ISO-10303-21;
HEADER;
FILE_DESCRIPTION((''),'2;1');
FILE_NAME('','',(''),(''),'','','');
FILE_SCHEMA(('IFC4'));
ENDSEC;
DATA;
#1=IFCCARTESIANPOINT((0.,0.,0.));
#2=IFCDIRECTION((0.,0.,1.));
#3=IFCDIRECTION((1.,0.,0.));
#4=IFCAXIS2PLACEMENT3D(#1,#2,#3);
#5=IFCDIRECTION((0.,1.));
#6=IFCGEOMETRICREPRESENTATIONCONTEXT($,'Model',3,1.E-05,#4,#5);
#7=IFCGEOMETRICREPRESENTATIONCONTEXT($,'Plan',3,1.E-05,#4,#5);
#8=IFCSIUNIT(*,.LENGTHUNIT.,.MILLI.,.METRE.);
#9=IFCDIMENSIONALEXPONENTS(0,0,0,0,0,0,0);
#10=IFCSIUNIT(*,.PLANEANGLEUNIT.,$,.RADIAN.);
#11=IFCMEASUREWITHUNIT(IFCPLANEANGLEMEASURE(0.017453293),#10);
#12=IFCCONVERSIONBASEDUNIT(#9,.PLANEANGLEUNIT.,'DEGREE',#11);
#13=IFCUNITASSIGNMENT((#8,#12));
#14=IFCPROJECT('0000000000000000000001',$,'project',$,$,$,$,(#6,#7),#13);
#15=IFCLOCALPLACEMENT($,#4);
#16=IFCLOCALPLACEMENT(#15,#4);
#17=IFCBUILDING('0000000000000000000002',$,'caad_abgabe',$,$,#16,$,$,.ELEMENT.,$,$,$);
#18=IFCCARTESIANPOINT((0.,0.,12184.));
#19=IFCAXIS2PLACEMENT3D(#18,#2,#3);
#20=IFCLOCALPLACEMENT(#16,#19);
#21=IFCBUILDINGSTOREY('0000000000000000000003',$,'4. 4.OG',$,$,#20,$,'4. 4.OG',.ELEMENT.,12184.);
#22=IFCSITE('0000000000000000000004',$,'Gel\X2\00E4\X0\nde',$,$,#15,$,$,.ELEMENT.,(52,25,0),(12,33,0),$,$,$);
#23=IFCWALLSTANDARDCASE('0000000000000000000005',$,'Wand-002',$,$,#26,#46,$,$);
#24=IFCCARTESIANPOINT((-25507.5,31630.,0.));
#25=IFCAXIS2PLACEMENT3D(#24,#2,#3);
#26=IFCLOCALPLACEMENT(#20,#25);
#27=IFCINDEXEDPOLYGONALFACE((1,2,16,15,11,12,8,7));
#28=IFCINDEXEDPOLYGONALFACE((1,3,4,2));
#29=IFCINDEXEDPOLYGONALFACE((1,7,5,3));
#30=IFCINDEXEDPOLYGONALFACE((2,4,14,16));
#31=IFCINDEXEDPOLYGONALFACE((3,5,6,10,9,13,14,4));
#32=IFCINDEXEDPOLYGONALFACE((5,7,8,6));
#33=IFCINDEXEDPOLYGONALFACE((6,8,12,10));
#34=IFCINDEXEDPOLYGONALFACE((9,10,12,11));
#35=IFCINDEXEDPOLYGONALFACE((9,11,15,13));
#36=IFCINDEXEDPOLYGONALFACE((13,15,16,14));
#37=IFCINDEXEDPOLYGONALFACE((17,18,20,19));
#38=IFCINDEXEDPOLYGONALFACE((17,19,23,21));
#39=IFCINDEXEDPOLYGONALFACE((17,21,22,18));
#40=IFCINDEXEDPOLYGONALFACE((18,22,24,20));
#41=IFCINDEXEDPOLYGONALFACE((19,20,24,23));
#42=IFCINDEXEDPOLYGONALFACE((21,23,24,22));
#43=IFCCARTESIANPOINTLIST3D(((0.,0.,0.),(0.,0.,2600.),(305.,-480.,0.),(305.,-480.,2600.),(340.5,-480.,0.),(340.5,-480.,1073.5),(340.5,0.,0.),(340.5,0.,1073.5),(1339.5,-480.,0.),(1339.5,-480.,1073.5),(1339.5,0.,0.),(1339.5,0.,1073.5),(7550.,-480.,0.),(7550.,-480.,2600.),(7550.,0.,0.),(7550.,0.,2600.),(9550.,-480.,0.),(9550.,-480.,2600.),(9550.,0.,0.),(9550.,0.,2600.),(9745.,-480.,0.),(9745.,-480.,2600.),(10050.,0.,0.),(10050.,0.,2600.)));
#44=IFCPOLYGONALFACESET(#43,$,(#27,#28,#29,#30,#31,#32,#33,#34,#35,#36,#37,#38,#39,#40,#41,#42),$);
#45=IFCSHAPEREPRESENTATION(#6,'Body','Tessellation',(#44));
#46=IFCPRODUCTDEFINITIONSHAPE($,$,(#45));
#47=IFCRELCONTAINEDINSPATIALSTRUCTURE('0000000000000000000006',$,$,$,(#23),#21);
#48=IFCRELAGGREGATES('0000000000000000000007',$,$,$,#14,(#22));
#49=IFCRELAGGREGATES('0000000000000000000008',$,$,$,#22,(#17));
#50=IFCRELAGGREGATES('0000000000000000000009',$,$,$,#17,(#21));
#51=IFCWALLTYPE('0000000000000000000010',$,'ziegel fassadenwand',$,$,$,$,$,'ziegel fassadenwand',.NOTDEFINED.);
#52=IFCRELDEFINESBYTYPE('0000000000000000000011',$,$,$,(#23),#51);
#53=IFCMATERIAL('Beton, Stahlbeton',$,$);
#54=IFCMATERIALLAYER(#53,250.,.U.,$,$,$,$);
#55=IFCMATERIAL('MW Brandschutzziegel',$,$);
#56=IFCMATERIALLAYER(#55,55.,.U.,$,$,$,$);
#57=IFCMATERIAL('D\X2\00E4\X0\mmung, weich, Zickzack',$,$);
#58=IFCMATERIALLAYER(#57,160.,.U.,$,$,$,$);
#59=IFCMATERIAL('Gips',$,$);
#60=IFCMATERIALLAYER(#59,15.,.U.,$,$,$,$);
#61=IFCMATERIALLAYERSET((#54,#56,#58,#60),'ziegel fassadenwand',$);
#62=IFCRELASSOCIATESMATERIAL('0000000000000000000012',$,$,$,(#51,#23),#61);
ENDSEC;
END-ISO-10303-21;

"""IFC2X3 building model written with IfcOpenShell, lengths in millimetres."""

from ifc_helpers import new_model, entity, si_unit, converted_unit, direction, frame, frame_2d, origin_with_axes, place, context, project, spatial, polyline, rectangle, outline, extrude, material, layer, layer_set, layer_usage, type_object, element, save


model = new_model("IFC2X3")

# Units and contexts
model_context = context("Model", 3, precision=1e-05, world=origin_with_axes(), true_north=direction((0.0, 1.0)))
plan_context = context("Plan", 3, precision=1e-05, world=origin_with_axes(), true_north=direction((0.0, 1.0)))
ifc_project = project(units=[si_unit("LENGTHUNIT", "METRE", prefix="MILLI"), converted_unit("PLANEANGLEUNIT", "DEGREE", entity("IfcPlaneAngleMeasure", 0.017453293), si_unit("PLANEANGLEUNIT", "RADIAN"), dimensions=[0, 0, 0, 0, 0, 0, 0])], contexts=[model_context, plan_context])

# Site, building, storey
site_placement = place(None, origin_with_axes())
site = spatial("IfcSite", under=ifc_project, at=site_placement, Name="Gelände", CompositionType="ELEMENT", RefLatitude=(52, 25, 0), RefLongitude=(12, 33, 0))
building_placement = place(site_placement, origin_with_axes())
building = spatial("IfcBuilding", under=site, at=building_placement, Name="caad_abgabe", CompositionType="ELEMENT")
storey_placement = place(building_placement, frame((0.0, 0.0, 12184.0), z_axis=(0.0, 0.0, 1.0), x_axis=(1.0, 0.0, 0.0)))
storey = spatial("IfcBuildingStorey", under=building, at=storey_placement, Name="4. 4.OG", LongName="4. 4.OG", CompositionType="ELEMENT", Elevation=12184.0)

# Shared definitions
ifc_material_1 = material(Name="Gips")
ifc_material_2 = material(Name="Beton, Stahlbeton")

# Wall, openings
ifc_layer_1 = layer(ifc_material_2, 250.0, ventilated="UNKNOWN")
ifc_material_3 = material(Name="MW Brandschutzziegel")
ifc_layer_2 = layer(ifc_material_3, 55.0, ventilated="UNKNOWN")
ifc_material_4 = material(Name="Dämmung, weich, Zickzack")
ifc_layer_3 = layer(ifc_material_4, 160.0, ventilated="UNKNOWN")
ifc_layer_4 = layer(ifc_material_1, 15.0, ventilated="UNKNOWN")
ifc_layer_set_1 = layer_set([ifc_layer_1, ifc_layer_2, ifc_layer_3, ifc_layer_4], Name="ziegel fassadenwand")
wall_type_1 = type_object("IfcWallType", Name="ziegel fassadenwand", ElementType="ziegel fassadenwand", PredefinedType="NOTDEFINED", material=ifc_layer_set_1)
ifc_layer_usage_1 = layer_usage(ifc_layer_set_1, "AXIS2", "NEGATIVE", 0.0)
wall_1_placement = place(storey_placement, frame((-25507.5, 31630.0, 0.0), z_axis=(0.0, 0.0, 1.0), x_axis=(1.0, 0.0, 0.0)))
wall_1 = element("IfcWallStandardCase", 1, at=wall_1_placement, inside=storey, type_object=wall_type_1, material=ifc_layer_usage_1, Name="Wand-002", context=model_context, shape_type="SweptSolid", body=[
    extrude(outline(polyline([(305.0, -480.0), (9745.0, -480.0), (10050.0, 0.0), (0.0, 0.0), (305.0, -480.0)])), origin_with_axes(), (0.0, 0.0, 1.0), 2600.0),
])
opening_1_placement = place(wall_1_placement, frame((790.0, -480.0, -1526.0), z_axis=(0.0, 0.0, 1.0), x_axis=(1.0, 0.0, 0.0)))
element("IfcOpeningElement", 2, at=opening_1_placement, cuts=wall_1, ObjectType="Opening", context=model_context, shape_type="SweptSolid", body=[
    extrude(rectangle(XDim=899.0, YDim=1499.0, at=frame_2d((0.0, 750.0), x_axis=(1.0, 0.0))), frame((0.0, 0.0, 0.0), z_axis=(0.0, 1.0, 0.0), x_axis=(-1.0, 0.0, 0.0)), (0.0, 0.0, 1.0), 480.0),
])
opening_2_placement = place(wall_1_placement, frame((840.0, -480.0, -1526.0), z_axis=(0.0, 0.0, 1.0), x_axis=(1.0, 0.0, 0.0)))
element("IfcOpeningElement", 3, at=opening_2_placement, cuts=wall_1, ObjectType="Opening", context=model_context, shape_type="SweptSolid", body=[
    extrude(rectangle(XDim=999.0, YDim=2599.0, at=frame_2d((0.0, 1300.0), x_axis=(1.0, 0.0))), frame((0.0, 0.0, 0.0), z_axis=(0.0, 1.0, 0.0), x_axis=(-1.0, 0.0, 0.0)), (0.0, 0.0, 1.0), 480.0),
])
opening_3_placement = place(wall_1_placement, frame((8550.0, -480.0, 0.0), z_axis=(0.0, 0.0, 1.0), x_axis=(1.0, 0.0, 0.0)))
element("IfcOpeningElement", 4, at=opening_3_placement, cuts=wall_1, ObjectType="Opening", context=model_context, shape_type="SweptSolid", body=[
    extrude(rectangle(XDim=2000.0, YDim=2600.0, at=frame_2d((0.0, 1300.0), x_axis=(1.0, 0.0))), frame((0.0, 0.0, 0.0), z_axis=(0.0, 1.0, 0.0), x_axis=(-1.0, 0.0, 0.0)), (0.0, 0.0, 1.0), 480.0),
])

save(model, "model.ifc")
